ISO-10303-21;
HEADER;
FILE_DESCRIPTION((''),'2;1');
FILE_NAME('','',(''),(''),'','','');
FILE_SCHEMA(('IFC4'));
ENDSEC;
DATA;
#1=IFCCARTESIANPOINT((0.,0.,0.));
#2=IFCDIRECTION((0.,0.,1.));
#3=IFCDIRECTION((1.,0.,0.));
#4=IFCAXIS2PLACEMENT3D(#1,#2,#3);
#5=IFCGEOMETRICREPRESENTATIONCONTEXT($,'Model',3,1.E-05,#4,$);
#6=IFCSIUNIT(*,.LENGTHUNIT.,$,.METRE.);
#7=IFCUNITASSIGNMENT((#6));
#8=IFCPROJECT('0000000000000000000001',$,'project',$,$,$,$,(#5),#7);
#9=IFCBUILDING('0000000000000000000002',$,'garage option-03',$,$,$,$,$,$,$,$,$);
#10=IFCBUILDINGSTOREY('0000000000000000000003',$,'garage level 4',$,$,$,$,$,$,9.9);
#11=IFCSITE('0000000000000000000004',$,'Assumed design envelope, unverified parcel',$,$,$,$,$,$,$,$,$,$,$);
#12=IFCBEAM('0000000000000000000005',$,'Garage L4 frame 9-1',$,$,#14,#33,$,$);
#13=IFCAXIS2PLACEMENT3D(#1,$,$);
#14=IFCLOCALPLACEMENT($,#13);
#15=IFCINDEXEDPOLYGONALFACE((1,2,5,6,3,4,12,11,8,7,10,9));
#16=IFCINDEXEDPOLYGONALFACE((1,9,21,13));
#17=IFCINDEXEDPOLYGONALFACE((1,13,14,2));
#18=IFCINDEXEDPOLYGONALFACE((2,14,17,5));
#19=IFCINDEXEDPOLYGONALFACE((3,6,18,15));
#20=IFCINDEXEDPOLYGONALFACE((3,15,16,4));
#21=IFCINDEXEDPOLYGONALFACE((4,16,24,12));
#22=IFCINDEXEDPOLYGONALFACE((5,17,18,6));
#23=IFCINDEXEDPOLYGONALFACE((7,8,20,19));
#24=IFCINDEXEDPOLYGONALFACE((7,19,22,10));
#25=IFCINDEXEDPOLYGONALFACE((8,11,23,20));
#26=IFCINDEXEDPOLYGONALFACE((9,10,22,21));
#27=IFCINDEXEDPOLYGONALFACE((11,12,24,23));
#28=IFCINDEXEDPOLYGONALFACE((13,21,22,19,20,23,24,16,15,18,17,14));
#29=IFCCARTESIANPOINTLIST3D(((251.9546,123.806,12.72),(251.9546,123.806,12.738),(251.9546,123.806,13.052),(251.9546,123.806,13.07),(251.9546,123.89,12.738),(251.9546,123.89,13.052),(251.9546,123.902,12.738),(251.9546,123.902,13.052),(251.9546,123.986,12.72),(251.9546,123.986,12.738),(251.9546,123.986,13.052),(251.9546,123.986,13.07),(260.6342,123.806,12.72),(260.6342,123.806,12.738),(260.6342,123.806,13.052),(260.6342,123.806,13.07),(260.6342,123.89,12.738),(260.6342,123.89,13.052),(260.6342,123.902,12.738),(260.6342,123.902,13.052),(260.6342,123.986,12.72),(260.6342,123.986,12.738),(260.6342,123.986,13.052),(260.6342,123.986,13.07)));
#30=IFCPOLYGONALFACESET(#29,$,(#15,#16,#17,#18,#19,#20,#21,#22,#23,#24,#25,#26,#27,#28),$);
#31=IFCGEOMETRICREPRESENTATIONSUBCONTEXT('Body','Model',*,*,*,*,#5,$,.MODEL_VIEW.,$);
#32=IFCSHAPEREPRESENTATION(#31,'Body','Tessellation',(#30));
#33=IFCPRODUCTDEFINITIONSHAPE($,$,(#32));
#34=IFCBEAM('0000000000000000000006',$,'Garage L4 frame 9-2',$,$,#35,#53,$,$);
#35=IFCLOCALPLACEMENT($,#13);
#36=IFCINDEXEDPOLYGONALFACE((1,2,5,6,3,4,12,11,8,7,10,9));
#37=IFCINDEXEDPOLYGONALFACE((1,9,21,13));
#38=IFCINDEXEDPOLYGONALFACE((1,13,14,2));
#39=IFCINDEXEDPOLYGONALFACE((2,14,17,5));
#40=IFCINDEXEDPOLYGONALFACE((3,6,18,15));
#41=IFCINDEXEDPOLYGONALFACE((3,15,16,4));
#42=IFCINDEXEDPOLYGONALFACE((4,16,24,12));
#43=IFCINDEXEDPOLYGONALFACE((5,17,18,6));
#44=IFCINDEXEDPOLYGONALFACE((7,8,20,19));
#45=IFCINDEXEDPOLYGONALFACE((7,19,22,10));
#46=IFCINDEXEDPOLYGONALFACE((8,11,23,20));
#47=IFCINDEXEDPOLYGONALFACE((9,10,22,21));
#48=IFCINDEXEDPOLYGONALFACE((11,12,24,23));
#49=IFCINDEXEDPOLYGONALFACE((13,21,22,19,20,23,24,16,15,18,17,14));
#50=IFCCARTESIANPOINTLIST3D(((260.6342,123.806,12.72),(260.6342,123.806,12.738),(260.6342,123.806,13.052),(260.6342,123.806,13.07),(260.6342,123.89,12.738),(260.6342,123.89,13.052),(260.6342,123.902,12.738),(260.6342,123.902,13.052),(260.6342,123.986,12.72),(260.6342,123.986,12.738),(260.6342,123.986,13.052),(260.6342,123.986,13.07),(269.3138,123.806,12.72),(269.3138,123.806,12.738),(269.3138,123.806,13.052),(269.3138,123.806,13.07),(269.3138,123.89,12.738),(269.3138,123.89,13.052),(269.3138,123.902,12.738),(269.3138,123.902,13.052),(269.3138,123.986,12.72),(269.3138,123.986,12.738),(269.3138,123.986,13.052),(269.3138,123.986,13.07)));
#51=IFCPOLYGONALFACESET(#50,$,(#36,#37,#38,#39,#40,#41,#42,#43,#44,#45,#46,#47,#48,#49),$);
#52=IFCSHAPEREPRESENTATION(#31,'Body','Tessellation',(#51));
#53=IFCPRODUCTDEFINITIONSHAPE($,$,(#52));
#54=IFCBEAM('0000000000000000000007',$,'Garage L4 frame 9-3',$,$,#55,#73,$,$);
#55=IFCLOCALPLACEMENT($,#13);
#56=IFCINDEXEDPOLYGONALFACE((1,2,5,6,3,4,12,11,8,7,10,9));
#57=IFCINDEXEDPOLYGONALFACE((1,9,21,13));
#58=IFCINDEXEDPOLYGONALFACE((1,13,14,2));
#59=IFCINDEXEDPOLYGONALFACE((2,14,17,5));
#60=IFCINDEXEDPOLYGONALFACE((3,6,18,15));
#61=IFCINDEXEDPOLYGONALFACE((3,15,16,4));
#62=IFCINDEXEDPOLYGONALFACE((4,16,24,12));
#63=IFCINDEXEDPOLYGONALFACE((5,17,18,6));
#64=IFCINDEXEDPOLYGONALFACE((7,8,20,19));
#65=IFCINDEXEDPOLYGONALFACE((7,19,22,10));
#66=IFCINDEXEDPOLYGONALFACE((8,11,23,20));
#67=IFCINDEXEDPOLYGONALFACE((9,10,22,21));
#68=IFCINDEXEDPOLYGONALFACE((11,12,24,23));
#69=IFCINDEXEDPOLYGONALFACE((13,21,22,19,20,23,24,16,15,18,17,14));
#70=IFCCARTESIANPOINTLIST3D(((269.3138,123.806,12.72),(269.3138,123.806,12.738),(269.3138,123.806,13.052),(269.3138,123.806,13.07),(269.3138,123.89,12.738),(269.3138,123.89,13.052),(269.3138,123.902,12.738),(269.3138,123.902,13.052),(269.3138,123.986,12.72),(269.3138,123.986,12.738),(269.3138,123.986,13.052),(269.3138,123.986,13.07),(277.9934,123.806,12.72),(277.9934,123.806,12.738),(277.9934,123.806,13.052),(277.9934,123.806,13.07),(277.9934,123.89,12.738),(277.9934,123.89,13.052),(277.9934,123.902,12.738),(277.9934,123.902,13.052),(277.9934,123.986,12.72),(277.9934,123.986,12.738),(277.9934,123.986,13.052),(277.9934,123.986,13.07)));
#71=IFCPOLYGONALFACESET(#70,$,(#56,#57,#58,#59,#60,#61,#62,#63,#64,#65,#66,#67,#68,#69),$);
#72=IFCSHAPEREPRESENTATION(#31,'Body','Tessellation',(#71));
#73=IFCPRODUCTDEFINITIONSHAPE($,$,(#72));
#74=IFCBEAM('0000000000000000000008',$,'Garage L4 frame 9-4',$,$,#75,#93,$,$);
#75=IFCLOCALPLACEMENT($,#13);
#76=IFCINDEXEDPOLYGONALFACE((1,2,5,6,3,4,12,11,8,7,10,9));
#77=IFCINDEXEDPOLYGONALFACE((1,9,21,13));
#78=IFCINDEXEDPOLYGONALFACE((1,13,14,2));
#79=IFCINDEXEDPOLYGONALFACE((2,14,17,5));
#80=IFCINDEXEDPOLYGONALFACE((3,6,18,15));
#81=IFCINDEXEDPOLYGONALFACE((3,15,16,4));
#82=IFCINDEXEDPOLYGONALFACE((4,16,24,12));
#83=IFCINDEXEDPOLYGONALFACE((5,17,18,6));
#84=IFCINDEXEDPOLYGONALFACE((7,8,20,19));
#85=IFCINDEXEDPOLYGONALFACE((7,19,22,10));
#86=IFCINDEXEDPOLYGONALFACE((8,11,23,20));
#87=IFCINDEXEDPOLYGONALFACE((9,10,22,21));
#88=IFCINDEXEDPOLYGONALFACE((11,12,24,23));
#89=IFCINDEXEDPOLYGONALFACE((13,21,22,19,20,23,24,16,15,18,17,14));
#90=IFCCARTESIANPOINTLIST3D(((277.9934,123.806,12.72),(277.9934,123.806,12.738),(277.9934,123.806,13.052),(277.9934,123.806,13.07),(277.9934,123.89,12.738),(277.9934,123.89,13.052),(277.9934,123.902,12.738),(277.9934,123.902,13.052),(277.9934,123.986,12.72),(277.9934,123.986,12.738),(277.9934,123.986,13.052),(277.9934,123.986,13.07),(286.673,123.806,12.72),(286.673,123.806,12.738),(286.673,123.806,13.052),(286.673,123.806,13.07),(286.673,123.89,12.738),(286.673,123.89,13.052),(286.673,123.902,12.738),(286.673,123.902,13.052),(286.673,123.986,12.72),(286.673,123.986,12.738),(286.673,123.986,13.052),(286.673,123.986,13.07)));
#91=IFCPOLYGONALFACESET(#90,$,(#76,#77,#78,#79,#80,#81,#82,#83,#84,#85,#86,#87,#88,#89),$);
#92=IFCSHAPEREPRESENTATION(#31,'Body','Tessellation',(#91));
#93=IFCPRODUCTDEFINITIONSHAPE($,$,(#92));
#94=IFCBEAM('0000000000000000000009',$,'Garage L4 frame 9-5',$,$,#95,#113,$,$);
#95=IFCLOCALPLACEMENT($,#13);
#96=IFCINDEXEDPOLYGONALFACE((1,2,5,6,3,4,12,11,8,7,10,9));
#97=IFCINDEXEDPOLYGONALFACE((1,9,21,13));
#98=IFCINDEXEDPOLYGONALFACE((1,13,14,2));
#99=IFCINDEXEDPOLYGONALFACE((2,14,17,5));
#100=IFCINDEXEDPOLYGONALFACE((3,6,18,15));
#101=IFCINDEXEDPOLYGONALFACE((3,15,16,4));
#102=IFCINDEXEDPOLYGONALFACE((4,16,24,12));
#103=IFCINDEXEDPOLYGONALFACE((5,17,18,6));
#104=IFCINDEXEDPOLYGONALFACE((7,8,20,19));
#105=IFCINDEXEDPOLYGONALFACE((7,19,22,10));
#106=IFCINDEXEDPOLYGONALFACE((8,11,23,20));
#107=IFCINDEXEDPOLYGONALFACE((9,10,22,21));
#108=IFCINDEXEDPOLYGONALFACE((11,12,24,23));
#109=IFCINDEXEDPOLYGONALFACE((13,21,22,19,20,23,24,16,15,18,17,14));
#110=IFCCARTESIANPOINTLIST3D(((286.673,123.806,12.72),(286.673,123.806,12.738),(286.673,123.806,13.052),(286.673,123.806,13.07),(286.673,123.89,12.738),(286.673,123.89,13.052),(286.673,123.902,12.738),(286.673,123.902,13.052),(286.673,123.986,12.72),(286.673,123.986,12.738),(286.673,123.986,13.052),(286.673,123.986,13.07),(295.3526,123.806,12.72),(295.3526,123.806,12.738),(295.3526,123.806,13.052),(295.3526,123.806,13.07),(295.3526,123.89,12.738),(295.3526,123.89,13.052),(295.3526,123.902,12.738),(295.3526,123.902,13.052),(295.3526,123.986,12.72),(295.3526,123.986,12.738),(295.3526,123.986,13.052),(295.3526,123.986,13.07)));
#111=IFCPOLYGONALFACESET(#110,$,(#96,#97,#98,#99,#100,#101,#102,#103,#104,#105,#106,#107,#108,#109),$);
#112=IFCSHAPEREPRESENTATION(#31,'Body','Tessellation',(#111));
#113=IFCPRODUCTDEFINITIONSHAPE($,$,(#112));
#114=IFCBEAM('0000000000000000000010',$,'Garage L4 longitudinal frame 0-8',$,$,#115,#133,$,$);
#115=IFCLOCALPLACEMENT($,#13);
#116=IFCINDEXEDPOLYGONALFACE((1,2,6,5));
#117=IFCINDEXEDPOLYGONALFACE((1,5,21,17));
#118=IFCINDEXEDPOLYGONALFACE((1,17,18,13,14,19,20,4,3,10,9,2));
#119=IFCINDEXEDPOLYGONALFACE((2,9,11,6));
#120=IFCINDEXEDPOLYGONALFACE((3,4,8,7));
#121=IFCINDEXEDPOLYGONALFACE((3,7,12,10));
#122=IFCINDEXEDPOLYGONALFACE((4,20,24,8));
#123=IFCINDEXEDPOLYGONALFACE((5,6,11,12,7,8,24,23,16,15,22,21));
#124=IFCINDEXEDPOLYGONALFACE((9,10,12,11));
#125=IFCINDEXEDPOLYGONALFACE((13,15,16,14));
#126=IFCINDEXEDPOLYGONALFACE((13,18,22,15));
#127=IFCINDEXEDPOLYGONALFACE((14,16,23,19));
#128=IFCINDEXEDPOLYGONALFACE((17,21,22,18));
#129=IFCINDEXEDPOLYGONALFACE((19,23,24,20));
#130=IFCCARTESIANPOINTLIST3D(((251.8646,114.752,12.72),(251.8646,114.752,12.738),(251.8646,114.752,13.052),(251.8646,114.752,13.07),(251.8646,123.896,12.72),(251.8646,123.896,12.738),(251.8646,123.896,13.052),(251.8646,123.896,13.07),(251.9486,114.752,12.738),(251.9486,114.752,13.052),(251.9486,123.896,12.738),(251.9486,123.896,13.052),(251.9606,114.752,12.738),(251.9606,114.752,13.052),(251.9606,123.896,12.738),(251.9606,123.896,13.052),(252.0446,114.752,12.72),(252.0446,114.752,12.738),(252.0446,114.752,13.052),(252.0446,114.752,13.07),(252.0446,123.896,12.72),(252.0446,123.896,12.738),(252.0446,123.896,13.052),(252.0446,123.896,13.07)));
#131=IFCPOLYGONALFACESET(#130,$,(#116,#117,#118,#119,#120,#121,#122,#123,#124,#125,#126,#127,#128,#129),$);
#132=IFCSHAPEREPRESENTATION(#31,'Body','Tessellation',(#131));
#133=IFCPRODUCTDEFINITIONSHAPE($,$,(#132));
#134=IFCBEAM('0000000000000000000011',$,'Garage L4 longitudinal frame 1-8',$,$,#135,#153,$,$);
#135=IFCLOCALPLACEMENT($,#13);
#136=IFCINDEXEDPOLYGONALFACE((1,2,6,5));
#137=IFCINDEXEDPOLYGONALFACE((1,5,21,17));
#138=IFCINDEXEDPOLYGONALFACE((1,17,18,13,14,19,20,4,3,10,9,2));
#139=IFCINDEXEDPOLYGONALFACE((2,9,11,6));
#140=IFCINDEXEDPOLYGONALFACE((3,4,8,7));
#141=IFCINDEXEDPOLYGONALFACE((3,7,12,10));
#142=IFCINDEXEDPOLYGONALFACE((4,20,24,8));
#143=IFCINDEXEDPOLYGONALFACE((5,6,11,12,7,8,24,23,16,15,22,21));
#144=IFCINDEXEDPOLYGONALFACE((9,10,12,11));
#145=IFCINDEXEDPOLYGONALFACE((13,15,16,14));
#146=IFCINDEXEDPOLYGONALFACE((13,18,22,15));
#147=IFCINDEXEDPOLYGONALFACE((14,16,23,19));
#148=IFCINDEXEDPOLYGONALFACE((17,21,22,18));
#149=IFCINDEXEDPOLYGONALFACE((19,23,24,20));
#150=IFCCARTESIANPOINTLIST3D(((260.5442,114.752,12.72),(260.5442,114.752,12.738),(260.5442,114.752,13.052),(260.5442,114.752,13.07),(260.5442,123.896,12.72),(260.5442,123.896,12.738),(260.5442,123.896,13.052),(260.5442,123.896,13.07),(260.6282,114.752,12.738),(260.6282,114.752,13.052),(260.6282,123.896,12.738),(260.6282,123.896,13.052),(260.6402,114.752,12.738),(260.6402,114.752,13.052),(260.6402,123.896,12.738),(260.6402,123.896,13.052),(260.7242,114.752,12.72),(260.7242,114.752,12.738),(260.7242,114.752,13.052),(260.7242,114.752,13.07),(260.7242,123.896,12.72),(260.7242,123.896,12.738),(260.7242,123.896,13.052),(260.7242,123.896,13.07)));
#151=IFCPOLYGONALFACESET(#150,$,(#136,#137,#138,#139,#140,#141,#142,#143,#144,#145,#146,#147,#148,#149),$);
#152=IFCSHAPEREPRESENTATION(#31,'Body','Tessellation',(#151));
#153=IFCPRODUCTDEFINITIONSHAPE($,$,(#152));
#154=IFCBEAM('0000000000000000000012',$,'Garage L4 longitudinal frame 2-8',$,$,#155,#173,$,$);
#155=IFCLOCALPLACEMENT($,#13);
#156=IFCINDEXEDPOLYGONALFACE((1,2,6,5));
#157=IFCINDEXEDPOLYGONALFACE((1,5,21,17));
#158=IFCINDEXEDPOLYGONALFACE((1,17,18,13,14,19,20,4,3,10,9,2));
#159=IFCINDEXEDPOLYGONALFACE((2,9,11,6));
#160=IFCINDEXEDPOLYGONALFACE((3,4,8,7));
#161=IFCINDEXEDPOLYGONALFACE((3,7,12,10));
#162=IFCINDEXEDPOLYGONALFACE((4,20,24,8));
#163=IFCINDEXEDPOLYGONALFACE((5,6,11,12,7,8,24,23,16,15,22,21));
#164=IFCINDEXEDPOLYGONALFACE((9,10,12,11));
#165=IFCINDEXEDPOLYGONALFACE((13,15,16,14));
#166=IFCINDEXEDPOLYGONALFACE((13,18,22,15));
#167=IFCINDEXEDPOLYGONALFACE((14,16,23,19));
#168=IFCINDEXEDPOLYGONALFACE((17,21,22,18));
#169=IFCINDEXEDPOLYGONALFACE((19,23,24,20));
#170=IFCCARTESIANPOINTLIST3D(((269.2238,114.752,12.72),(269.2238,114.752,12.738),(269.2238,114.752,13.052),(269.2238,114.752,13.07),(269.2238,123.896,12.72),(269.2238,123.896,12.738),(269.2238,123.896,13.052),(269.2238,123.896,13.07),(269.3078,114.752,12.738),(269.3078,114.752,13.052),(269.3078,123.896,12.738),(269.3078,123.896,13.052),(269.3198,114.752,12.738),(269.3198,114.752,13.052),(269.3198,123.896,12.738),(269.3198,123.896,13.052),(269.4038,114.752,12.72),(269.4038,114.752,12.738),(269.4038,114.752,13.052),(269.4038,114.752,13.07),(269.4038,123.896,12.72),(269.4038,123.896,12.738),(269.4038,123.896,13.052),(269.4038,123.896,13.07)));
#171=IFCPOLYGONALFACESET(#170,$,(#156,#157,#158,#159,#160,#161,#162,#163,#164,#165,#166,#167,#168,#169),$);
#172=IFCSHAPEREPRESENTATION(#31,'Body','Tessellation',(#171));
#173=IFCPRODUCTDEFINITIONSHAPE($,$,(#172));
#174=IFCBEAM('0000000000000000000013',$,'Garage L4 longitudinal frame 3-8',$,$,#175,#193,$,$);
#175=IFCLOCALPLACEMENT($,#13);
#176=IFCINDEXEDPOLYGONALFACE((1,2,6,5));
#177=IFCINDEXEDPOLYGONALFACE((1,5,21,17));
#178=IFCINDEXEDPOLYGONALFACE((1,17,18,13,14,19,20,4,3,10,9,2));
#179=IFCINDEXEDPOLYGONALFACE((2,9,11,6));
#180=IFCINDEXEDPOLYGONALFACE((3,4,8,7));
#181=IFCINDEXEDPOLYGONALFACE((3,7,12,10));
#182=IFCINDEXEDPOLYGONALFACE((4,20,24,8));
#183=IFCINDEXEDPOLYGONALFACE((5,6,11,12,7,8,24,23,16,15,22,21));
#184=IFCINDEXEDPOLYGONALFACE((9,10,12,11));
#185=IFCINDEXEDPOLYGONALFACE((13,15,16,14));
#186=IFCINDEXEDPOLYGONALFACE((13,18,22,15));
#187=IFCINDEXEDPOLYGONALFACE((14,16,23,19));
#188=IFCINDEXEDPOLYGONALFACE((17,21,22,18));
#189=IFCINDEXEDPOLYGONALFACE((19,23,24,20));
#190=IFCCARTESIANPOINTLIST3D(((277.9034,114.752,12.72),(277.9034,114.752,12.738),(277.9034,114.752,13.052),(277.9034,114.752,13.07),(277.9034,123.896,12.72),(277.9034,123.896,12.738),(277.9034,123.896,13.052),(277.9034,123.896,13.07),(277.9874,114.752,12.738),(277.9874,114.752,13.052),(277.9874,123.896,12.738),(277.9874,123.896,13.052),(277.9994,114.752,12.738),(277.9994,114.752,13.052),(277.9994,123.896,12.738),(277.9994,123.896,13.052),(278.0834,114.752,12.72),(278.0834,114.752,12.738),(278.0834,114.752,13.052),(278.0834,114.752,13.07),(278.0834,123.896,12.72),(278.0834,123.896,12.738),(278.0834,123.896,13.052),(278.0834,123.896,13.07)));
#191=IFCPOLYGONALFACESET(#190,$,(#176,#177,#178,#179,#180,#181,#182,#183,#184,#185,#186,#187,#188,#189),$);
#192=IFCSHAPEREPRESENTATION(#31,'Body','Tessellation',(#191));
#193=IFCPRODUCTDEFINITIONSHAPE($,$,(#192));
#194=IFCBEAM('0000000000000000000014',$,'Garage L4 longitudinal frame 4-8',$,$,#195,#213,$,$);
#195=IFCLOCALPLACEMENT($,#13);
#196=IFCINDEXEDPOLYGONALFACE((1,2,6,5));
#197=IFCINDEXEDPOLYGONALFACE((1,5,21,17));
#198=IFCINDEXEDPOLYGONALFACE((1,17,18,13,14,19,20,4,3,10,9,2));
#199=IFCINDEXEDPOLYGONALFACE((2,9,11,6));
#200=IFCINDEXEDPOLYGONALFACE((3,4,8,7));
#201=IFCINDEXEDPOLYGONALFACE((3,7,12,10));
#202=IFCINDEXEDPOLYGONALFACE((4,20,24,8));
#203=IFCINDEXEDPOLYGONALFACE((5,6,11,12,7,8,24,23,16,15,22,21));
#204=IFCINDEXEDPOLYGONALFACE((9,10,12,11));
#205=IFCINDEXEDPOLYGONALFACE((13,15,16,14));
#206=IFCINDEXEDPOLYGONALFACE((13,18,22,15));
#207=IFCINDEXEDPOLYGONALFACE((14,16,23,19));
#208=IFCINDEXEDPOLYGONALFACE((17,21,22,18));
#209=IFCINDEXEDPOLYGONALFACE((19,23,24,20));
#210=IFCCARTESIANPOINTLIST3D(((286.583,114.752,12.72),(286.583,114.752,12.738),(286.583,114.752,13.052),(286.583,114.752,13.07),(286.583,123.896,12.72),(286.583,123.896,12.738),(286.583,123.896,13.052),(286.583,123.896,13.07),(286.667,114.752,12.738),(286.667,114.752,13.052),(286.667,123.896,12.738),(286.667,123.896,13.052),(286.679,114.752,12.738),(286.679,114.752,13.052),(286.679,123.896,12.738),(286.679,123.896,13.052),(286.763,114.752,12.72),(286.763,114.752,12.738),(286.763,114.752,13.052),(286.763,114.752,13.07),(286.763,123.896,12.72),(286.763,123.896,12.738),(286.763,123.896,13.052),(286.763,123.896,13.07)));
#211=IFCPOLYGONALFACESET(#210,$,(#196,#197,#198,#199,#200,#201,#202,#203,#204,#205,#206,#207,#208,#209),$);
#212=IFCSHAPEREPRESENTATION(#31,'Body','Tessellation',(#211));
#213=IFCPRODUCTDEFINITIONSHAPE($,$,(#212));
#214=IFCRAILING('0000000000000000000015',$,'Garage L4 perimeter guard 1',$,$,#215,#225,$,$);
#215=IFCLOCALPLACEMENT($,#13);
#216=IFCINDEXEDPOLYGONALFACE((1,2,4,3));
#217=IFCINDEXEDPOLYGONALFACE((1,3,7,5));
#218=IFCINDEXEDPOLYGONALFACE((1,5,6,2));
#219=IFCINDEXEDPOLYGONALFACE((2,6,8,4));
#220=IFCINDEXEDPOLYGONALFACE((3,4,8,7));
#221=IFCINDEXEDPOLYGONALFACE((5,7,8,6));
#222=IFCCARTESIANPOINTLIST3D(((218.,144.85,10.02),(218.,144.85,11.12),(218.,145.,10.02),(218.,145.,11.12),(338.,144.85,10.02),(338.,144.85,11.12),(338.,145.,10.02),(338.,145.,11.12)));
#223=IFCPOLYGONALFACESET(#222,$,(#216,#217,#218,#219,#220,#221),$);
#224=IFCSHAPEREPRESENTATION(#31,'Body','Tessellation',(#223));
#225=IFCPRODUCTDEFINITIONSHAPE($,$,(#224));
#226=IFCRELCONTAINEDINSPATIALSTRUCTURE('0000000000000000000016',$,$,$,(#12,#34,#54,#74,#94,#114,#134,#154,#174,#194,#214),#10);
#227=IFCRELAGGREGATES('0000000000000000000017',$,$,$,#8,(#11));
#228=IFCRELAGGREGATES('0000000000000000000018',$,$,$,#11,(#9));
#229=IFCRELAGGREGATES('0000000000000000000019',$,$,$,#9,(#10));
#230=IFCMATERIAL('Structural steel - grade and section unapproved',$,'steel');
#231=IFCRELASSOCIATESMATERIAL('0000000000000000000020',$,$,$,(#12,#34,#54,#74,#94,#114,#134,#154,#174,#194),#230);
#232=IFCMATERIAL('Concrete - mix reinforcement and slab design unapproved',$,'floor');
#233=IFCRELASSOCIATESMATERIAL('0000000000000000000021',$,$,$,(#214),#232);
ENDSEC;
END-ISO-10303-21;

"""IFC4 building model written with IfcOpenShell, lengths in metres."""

from ifc_helpers import new_model, si_unit, frame, origin_with_axes, place, context, subcontext, project, spatial, rectangle, i_section, extrude, material, element, save


model = new_model("IFC4")

# Units and contexts
model_context = context("Model", 3, precision=1e-05, world=origin_with_axes())
body_context = subcontext(model_context, "Body", "Model", "MODEL_VIEW")
ifc_project = project(units=[si_unit("LENGTHUNIT", "METRE")], contexts=[model_context])

# Site, building, storey
site = spatial("IfcSite", under=ifc_project, Name="Assumed design envelope, unverified parcel")
building = spatial("IfcBuilding", under=site, Name="garage option-03")
storey = spatial("IfcBuildingStorey", under=building, Name="garage level 4", Elevation=9.9)

# Shared definitions
ifc_material_1 = material(Name="Concrete - mix reinforcement and slab design unapproved", Category="floor")

# Beams
ifc_material_2 = material(Name="Structural steel - grade and section unapproved", Category="steel")
beam_1_placement = place(None, frame((251.9546, 123.896, 12.895), z_axis=(1.0, 0.0, 0.0), x_axis=(0.0, 1.0, 0.0)))
element("IfcBeam", 1, at=beam_1_placement, inside=storey, material=ifc_material_2, Name="Garage L4 frame 9-1", context=body_context, shape_type="SweptSolid", body=[
    extrude(i_section(OverallWidth=0.18, OverallDepth=0.35, WebThickness=0.012, FlangeThickness=0.018, FilletRadius=0.0), origin_with_axes(), (0.0, 0.0, 1.0), 8.6796),
])
beam_2_placement = place(None, frame((260.6342, 123.896, 12.895), z_axis=(1.0, 0.0, 0.0), x_axis=(0.0, 1.0, 0.0)))
element("IfcBeam", 2, at=beam_2_placement, inside=storey, material=ifc_material_2, Name="Garage L4 frame 9-2", context=body_context, shape_type="SweptSolid", body=[
    extrude(i_section(OverallWidth=0.18, OverallDepth=0.35, WebThickness=0.012, FlangeThickness=0.018, FilletRadius=0.0), origin_with_axes(), (0.0, 0.0, 1.0), 8.6796),
])
for number, where, z_axis, x_axis, name in (
    (3, (269.3138, 123.896, 12.895), (1.0, 0.0, 0.0), (0.0, 1.0, 0.0), "Garage L4 frame 9-3"),
    (4, (277.9934, 123.896, 12.895), (1.0, 0.0, 0.0), (0.0, 1.0, 0.0), "Garage L4 frame 9-4"),
    (5, (286.673, 123.896, 12.895), (1.0, 0.0, 0.0), (0.0, 1.0, 0.0), "Garage L4 frame 9-5"),
):
    element("IfcBeam", number, at=place(None, frame(where, z_axis=z_axis, x_axis=x_axis)), inside=storey, material=ifc_material_2, Name=name, context=body_context, shape_type="SweptSolid", body=[
        extrude(i_section(OverallWidth=0.18, OverallDepth=0.35, WebThickness=0.012, FlangeThickness=0.018, FilletRadius=0.0), origin_with_axes(), (0.0, 0.0, 1.0), 8.6796),
    ])
for number, where, z_axis, x_axis, name in (
    (6, (251.9546, 114.752, 12.895), (0.0, 1.0, 0.0), (-1.0, 0.0, 0.0), "Garage L4 longitudinal frame 0-8"),
    (7, (260.6342, 114.752, 12.895), (0.0, 1.0, 0.0), (-1.0, 0.0, 0.0), "Garage L4 longitudinal frame 1-8"),
    (8, (269.3138, 114.752, 12.895), (0.0, 1.0, 0.0), (-1.0, 0.0, 0.0), "Garage L4 longitudinal frame 2-8"),
    (9, (277.9934, 114.752, 12.895), (0.0, 1.0, 0.0), (-1.0, 0.0, 0.0), "Garage L4 longitudinal frame 3-8"),
    (10, (286.673, 114.752, 12.895), (0.0, 1.0, 0.0), (-1.0, 0.0, 0.0), "Garage L4 longitudinal frame 4-8"),
):
    element("IfcBeam", number, at=place(None, frame(where, z_axis=z_axis, x_axis=x_axis)), inside=storey, material=ifc_material_2, Name=name, context=body_context, shape_type="SweptSolid", body=[
        extrude(i_section(OverallWidth=0.18, OverallDepth=0.35, WebThickness=0.012, FlangeThickness=0.018, FilletRadius=0.0), origin_with_axes(), (0.0, 0.0, 1.0), 9.144),
    ])

# Railing
railing_placement = place(None, frame((278.0, 144.925, 10.02), z_axis=(0.0, 0.0, 1.0), x_axis=(1.0, 0.0, 0.0)))
element("IfcRailing", 11, at=railing_placement, inside=storey, material=ifc_material_1, Name="Garage L4 perimeter guard 1", context=body_context, shape_type="SweptSolid", body=[
    extrude(rectangle(XDim=120.0, YDim=0.15), origin_with_axes(), (0.0, 0.0, 1.0), 1.1),
])

save(model, "model.ifc")
